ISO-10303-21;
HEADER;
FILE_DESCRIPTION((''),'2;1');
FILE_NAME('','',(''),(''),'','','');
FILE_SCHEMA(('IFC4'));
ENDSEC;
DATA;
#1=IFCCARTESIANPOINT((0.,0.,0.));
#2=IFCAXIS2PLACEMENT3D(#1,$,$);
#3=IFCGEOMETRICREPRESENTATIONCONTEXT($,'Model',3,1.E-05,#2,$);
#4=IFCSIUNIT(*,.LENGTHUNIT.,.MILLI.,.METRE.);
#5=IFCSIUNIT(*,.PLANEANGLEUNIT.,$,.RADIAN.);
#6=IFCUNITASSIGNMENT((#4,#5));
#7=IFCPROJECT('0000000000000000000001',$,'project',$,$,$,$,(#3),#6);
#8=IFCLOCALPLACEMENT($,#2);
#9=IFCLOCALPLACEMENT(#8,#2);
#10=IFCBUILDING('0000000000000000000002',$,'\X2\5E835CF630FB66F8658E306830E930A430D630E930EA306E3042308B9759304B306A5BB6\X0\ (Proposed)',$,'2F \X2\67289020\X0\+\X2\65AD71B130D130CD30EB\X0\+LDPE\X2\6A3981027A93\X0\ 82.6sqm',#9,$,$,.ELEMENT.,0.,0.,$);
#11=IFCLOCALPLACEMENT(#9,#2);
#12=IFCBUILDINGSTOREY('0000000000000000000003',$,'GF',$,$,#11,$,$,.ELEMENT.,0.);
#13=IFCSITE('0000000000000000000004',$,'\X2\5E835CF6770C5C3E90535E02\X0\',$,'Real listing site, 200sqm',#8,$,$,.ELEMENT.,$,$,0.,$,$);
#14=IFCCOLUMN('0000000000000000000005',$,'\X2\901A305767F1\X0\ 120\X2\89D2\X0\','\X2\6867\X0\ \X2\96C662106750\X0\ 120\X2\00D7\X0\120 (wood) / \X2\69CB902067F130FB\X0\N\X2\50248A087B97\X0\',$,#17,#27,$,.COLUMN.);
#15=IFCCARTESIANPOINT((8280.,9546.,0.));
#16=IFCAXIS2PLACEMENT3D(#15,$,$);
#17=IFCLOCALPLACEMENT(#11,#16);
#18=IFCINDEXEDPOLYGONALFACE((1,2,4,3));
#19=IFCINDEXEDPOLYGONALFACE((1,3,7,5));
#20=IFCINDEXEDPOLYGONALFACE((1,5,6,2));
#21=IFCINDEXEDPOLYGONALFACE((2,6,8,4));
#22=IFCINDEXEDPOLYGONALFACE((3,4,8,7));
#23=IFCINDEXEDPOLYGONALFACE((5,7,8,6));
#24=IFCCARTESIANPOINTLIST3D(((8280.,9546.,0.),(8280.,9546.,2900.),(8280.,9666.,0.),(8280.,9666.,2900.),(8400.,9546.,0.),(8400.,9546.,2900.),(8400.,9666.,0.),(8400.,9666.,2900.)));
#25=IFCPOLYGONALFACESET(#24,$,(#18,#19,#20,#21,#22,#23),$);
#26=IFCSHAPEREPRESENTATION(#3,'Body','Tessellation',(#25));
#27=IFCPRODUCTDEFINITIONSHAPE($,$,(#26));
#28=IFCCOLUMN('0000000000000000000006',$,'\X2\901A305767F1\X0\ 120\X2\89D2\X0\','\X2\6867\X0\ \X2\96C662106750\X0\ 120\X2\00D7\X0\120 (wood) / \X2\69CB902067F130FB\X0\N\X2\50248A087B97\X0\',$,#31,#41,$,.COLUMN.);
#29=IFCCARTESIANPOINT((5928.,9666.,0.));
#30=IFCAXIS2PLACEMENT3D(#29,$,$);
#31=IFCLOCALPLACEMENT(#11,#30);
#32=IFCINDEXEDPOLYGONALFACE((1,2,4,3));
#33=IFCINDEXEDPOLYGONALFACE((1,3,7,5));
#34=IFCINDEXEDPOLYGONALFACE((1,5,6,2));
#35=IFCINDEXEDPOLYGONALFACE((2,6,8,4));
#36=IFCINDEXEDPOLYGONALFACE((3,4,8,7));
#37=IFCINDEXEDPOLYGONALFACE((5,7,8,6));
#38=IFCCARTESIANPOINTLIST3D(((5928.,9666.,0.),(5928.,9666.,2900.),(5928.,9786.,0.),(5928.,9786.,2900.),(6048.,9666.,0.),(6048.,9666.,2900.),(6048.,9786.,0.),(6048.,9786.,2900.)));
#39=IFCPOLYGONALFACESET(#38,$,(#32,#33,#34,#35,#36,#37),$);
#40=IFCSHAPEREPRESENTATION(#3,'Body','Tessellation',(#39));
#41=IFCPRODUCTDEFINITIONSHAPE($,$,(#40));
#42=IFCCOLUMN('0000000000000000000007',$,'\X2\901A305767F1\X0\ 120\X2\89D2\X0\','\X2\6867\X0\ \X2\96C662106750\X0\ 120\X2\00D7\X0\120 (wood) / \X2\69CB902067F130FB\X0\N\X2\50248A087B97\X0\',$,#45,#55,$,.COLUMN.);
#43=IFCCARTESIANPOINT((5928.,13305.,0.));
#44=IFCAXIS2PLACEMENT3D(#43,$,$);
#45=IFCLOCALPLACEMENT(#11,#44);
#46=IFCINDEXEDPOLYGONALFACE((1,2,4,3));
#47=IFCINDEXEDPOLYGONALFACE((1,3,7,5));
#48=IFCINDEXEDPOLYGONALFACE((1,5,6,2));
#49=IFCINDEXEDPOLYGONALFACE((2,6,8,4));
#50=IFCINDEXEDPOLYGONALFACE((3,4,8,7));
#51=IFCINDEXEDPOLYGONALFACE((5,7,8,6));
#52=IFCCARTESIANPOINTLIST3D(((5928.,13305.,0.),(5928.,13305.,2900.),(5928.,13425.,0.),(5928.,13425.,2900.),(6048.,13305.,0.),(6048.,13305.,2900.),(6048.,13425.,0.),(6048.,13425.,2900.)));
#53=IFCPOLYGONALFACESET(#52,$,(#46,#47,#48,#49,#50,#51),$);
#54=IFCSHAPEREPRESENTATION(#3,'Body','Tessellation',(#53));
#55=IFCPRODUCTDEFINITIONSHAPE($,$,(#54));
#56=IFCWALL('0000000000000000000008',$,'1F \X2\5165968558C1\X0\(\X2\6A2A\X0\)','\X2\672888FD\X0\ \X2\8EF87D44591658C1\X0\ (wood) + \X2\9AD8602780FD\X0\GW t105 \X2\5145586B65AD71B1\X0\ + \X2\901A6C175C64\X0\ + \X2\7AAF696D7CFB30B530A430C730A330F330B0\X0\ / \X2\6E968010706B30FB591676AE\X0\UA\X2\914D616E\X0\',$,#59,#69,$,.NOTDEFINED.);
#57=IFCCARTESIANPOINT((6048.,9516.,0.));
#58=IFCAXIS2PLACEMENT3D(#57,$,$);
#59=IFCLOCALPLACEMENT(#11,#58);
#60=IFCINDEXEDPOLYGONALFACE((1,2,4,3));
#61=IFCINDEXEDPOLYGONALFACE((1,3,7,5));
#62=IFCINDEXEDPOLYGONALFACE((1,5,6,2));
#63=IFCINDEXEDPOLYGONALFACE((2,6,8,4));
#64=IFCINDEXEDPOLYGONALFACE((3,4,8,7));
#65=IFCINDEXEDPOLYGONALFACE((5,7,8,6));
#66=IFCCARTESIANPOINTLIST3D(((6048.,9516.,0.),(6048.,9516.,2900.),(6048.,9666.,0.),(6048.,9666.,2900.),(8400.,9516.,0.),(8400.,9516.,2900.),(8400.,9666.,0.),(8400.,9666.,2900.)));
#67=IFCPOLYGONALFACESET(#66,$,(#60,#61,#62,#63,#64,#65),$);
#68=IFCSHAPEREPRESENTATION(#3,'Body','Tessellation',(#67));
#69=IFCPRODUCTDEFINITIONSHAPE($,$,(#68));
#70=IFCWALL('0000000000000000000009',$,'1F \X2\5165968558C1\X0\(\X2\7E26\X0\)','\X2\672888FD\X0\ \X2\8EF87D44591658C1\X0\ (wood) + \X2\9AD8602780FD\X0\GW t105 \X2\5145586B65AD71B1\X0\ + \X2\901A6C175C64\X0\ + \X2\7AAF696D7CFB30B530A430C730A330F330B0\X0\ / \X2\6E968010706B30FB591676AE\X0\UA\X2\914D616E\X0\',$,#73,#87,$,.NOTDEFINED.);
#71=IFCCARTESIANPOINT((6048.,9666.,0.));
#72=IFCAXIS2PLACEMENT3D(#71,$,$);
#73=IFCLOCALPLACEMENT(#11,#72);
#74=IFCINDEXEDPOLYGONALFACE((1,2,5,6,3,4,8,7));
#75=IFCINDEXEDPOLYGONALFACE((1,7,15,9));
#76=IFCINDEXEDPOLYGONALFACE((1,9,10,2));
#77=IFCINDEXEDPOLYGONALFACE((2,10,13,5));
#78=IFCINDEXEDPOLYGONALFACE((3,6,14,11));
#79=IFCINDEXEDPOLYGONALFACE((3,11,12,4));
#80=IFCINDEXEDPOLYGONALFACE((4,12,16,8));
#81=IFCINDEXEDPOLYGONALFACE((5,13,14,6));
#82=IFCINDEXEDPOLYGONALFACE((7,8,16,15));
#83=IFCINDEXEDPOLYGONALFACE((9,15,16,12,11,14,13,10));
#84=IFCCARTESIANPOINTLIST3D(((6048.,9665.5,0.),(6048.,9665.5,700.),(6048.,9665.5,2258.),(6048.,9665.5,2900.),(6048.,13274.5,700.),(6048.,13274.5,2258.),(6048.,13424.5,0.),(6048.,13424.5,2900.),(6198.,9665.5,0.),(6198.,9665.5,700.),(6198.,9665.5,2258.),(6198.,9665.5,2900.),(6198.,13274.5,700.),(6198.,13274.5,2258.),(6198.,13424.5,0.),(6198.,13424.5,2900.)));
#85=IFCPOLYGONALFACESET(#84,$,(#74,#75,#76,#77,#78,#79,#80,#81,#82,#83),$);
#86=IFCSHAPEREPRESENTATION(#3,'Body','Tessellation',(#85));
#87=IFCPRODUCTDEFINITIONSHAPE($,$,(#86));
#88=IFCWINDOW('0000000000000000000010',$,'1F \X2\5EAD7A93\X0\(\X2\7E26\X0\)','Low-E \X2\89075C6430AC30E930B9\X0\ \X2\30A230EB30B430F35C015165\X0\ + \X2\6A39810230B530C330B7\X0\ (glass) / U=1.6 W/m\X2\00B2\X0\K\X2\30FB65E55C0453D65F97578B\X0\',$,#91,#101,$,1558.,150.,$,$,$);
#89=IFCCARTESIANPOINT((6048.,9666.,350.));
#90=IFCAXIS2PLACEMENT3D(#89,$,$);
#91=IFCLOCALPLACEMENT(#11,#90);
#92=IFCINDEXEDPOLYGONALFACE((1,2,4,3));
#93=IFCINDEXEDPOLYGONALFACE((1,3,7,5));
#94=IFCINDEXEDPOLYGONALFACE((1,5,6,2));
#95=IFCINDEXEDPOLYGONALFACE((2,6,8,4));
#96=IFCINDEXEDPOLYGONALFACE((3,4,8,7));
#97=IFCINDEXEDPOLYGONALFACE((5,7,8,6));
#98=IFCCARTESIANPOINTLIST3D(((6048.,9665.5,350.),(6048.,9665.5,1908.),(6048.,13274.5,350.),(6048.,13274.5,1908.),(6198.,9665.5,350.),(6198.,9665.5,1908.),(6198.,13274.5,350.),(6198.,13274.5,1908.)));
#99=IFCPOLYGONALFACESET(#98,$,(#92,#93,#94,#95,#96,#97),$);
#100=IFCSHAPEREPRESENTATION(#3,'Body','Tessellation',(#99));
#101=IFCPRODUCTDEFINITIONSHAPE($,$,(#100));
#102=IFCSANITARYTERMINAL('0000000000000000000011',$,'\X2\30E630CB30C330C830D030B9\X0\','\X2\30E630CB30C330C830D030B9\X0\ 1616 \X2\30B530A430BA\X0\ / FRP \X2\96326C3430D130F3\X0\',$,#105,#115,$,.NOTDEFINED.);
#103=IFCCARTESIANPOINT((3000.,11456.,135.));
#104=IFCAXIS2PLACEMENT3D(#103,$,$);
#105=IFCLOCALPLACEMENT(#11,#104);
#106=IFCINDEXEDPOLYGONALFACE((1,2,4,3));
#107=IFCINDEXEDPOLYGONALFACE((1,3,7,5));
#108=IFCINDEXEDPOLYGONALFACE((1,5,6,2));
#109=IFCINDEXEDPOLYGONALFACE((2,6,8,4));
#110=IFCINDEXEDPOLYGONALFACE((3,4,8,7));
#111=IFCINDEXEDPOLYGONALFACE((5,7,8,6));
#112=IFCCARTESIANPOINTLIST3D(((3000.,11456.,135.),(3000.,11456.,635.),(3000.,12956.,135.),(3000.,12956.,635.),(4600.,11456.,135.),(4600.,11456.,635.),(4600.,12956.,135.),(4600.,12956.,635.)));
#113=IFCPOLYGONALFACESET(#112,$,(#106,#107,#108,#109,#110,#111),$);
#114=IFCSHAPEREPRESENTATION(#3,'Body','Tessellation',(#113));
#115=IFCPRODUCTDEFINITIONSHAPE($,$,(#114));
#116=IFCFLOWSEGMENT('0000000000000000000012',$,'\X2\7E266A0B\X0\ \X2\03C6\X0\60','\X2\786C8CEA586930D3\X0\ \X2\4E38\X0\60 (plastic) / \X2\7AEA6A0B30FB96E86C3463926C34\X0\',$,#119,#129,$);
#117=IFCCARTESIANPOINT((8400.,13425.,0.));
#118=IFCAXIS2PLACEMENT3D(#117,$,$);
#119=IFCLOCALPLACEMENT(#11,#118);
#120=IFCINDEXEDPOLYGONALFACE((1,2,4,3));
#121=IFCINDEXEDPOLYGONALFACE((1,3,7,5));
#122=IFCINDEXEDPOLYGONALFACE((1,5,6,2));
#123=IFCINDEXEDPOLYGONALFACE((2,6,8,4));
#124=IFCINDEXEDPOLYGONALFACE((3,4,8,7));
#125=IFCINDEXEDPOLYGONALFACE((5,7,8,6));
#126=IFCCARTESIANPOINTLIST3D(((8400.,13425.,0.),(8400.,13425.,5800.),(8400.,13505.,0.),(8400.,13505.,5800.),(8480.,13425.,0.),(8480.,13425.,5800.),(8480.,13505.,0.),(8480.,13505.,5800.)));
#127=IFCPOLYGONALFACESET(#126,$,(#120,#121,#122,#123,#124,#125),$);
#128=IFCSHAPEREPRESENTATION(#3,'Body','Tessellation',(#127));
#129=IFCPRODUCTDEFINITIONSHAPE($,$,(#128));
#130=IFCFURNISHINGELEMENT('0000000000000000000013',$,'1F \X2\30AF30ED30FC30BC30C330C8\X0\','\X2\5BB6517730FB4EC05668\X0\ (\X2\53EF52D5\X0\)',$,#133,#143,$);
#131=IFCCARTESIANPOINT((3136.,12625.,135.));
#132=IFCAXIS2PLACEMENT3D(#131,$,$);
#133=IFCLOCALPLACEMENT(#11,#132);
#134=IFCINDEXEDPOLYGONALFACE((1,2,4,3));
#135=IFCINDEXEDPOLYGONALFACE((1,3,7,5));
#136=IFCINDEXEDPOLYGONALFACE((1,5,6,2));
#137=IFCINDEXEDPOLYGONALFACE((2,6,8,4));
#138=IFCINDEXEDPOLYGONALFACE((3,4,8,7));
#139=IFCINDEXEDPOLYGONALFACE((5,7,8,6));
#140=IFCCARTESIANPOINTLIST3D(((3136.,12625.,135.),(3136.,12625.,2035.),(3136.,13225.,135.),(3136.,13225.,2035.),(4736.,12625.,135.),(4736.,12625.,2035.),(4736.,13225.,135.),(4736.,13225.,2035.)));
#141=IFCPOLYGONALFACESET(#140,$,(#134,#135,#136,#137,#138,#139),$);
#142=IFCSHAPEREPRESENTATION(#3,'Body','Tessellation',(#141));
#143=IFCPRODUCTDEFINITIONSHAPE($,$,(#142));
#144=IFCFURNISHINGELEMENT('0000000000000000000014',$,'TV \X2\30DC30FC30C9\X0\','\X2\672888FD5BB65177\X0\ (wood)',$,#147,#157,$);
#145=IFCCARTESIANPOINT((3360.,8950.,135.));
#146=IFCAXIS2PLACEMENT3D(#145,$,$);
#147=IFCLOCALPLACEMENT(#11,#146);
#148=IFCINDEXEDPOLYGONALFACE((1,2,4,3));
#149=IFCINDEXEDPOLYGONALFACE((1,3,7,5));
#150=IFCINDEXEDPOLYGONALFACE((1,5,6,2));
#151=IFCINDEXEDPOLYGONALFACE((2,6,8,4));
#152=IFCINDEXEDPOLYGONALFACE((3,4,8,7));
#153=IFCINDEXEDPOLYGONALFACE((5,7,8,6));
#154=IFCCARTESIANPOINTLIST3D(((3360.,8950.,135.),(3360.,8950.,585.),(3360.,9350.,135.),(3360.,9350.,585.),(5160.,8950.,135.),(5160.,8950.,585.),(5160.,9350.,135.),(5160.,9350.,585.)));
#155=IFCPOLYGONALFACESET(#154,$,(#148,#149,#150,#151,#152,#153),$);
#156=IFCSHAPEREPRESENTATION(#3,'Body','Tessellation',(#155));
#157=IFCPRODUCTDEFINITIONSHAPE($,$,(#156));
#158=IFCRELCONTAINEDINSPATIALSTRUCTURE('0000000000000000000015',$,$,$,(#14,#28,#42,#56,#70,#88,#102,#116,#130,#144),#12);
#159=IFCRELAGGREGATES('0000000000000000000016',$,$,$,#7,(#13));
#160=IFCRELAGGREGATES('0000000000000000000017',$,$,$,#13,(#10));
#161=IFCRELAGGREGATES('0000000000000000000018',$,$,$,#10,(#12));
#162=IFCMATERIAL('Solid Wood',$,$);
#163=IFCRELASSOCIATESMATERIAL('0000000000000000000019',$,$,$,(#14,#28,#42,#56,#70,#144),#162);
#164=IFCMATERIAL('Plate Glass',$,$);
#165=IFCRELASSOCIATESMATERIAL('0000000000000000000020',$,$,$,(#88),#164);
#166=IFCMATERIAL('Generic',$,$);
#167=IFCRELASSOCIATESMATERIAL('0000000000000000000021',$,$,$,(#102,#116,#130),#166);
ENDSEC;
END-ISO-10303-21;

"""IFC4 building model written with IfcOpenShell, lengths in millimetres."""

from ifc_helpers import new_model, si_unit, frame, frame_2d, origin, place, context, project, spatial, rectangle, extrude, material, element, fill, save


model = new_model("IFC4")

# Units and contexts
model_context = context("Model", 3, precision=1e-05, world=origin())
ifc_project = project(units=[si_unit("LENGTHUNIT", "METRE", prefix="MILLI"), si_unit("PLANEANGLEUNIT", "RADIAN")], contexts=[model_context])

# Site, building, storey
site_placement = place(None, origin())
site = spatial("IfcSite", under=ifc_project, at=site_placement, Name="広島県尾道市", ObjectType="Real listing site, 200sqm", CompositionType="ELEMENT", RefElevation=0.0)
building_placement = place(site_placement, origin())
building = spatial("IfcBuilding", under=site, at=building_placement, Name="広島・書斎とライブラリのある静かな家 (Proposed)", ObjectType="2F 木造+断熱パネル+LDPE樹脂窓 82.6sqm", CompositionType="ELEMENT", ElevationOfRefHeight=0.0, ElevationOfTerrain=0.0)
storey_placement = place(building_placement, origin())
storey = spatial("IfcBuildingStorey", under=building, at=storey_placement, Name="GF", CompositionType="ELEMENT", Elevation=0.0)

# Columns
ifc_material_1 = material(Name="Solid Wood")
column_1_placement = place(storey_placement, frame((8280.0, 9546.0, 0.0)))
element("IfcColumn", 1, at=column_1_placement, inside=storey, material=ifc_material_1, Name="通し柱 120角", Description="桧 集成材 120×120 (wood) / 構造柱・N値計算", PredefinedType="COLUMN", context=model_context, shape_type="SweptSolid", body=[
    extrude(rectangle(XDim=120.0, YDim=120.0, at=frame_2d((60.0, 60.0))), frame((8280.0, 9546.0, 0.0)), (0.0, 0.0, 1.0), 2900.0),
])
column_2_placement = place(storey_placement, frame((5928.0, 9666.0, 0.0)))
element("IfcColumn", 2, at=column_2_placement, inside=storey, material=ifc_material_1, Name="通し柱 120角", Description="桧 集成材 120×120 (wood) / 構造柱・N値計算", PredefinedType="COLUMN", context=model_context, shape_type="SweptSolid", body=[
    extrude(rectangle(XDim=120.0, YDim=120.0, at=frame_2d((60.0, 60.0))), frame((5928.0, 9666.0, 0.0)), (0.0, 0.0, 1.0), 2900.0),
])
column_3_placement = place(storey_placement, frame((5928.0, 13305.0, 0.0)))
element("IfcColumn", 3, at=column_3_placement, inside=storey, material=ifc_material_1, Name="通し柱 120角", Description="桧 集成材 120×120 (wood) / 構造柱・N値計算", PredefinedType="COLUMN", context=model_context, shape_type="SweptSolid", body=[
    extrude(rectangle(XDim=120.0, YDim=120.0, at=frame_2d((60.0, 60.0))), frame((5928.0, 13305.0, 0.0)), (0.0, 0.0, 1.0), 2900.0),
])

# Wall
wall_1_placement = place(storey_placement, frame((6048.0, 9516.0, 0.0)))
element("IfcWall", 4, at=wall_1_placement, inside=storey, material=ifc_material_1, Name="1F 入隅壁(横)", Description="木製 軸組外壁 (wood) + 高性能GW t105 充填断熱 + 通気層 + 窯業系サイディング / 準耐火・外皮UA配慮", PredefinedType="NOTDEFINED", context=model_context, shape_type="SweptSolid", body=[
    extrude(rectangle(XDim=2352.0, YDim=150.0, at=frame_2d((1176.0, 75.0))), frame((6048.0, 9516.0, 0.0)), (0.0, 0.0, 1.0), 2900.0),
])

# Wall, opening, window
wall_2_placement = place(storey_placement, frame((6048.0, 9666.0, 0.0)))
wall_2 = element("IfcWall", 5, at=wall_2_placement, inside=storey, material=ifc_material_1, Name="1F 入隅壁(縦)", Description="木製 軸組外壁 (wood) + 高性能GW t105 充填断熱 + 通気層 + 窯業系サイディング / 準耐火・外皮UA配慮", PredefinedType="NOTDEFINED", context=model_context, shape_type="SweptSolid", body=[
    extrude(rectangle(XDim=150.0, YDim=3759.0, at=frame_2d((75.0, 1879.0))), frame((6048.0, 9666.0, 0.0)), (0.0, 0.0, 1.0), 2900.0),
])
opening_placement = place(storey_placement, frame((6048.0, 9666.0, 350.0)))
opening = element("IfcOpeningElement", 6, at=opening_placement, cuts=wall_2, PredefinedType="NOTDEFINED", context=model_context, shape_type="SweptSolid", body=[
    extrude(rectangle(XDim=150.0, YDim=3609.0, at=frame_2d((75.0, 1804.0))), frame((6048.0, 9666.0, 350.0)), (0.0, 0.0, 1.0), 1558.0),
])
ifc_material_2 = material(Name="Plate Glass")
window_placement = place(storey_placement, frame((6048.0, 9666.0, 350.0)))
window = element("IfcWindow", 7, at=window_placement, inside=storey, material=ifc_material_2, Name="1F 庭窓(縦)", Description="Low-E 複層ガラス アルゴン封入 + 樹脂サッシ (glass) / U=1.6 W/m²K・日射取得型", OverallHeight=1558.0, OverallWidth=150.0, context=model_context, shape_type="SweptSolid", body=[
    extrude(rectangle(XDim=150.0, YDim=3609.0, at=frame_2d((75.0, 1804.0))), frame((6048.0, 9666.0, 350.0)), (0.0, 0.0, 1.0), 1558.0),
])
fill(opening, window)

# Sanitary terminal
ifc_material_3 = material(Name="Generic")
sanitary_terminal_placement = place(storey_placement, frame((3000.0, 11456.0, 135.0)))
element("IfcSanitaryTerminal", 8, at=sanitary_terminal_placement, inside=storey, material=ifc_material_3, Name="ユニットバス", Description="ユニットバス 1616 サイズ / FRP 防水パン", PredefinedType="NOTDEFINED", context=model_context, shape_type="SweptSolid", body=[
    extrude(rectangle(XDim=1600.0, YDim=1500.0, at=frame_2d((800.0, 750.0))), frame((3000.0, 11456.0, 135.0)), (0.0, 0.0, 1.0), 500.0),
])

# Flow segment
flow_segment_placement = place(storey_placement, frame((8400.0, 13425.0, 0.0)))
element("IfcFlowSegment", 9, at=flow_segment_placement, inside=storey, material=ifc_material_3, Name="縦樋 φ60", Description="硬質塩ビ 丸60 (plastic) / 竪樋・雨水排水", context=model_context, shape_type="SweptSolid", body=[
    extrude(rectangle(XDim=80.0, YDim=80.0, at=frame_2d((40.0, 40.0))), frame((8400.0, 13425.0, 0.0)), (0.0, 0.0, 1.0), 5800.0),
])

# Furnishing elements
furnishing_1_placement = place(storey_placement, frame((3136.0, 12625.0, 135.0)))
element("IfcFurnishingElement", 10, at=furnishing_1_placement, inside=storey, material=ifc_material_3, Name="1F クローゼット", Description="家具・什器 (可動)", context=model_context, shape_type="SweptSolid", body=[
    extrude(rectangle(XDim=1600.0, YDim=600.0, at=frame_2d((800.0, 300.0))), frame((3136.0, 12625.0, 135.0)), (0.0, 0.0, 1.0), 1900.0),
])
furnishing_2_placement = place(storey_placement, frame((3360.0, 8950.0, 135.0)))
element("IfcFurnishingElement", 11, at=furnishing_2_placement, inside=storey, material=ifc_material_1, Name="TV ボード", Description="木製家具 (wood)", context=model_context, shape_type="SweptSolid", body=[
    extrude(rectangle(XDim=1800.0, YDim=400.0, at=frame_2d((900.0, 200.0))), frame((3360.0, 8950.0, 135.0)), (0.0, 0.0, 1.0), 450.0),
])

save(model, "model.ifc")
